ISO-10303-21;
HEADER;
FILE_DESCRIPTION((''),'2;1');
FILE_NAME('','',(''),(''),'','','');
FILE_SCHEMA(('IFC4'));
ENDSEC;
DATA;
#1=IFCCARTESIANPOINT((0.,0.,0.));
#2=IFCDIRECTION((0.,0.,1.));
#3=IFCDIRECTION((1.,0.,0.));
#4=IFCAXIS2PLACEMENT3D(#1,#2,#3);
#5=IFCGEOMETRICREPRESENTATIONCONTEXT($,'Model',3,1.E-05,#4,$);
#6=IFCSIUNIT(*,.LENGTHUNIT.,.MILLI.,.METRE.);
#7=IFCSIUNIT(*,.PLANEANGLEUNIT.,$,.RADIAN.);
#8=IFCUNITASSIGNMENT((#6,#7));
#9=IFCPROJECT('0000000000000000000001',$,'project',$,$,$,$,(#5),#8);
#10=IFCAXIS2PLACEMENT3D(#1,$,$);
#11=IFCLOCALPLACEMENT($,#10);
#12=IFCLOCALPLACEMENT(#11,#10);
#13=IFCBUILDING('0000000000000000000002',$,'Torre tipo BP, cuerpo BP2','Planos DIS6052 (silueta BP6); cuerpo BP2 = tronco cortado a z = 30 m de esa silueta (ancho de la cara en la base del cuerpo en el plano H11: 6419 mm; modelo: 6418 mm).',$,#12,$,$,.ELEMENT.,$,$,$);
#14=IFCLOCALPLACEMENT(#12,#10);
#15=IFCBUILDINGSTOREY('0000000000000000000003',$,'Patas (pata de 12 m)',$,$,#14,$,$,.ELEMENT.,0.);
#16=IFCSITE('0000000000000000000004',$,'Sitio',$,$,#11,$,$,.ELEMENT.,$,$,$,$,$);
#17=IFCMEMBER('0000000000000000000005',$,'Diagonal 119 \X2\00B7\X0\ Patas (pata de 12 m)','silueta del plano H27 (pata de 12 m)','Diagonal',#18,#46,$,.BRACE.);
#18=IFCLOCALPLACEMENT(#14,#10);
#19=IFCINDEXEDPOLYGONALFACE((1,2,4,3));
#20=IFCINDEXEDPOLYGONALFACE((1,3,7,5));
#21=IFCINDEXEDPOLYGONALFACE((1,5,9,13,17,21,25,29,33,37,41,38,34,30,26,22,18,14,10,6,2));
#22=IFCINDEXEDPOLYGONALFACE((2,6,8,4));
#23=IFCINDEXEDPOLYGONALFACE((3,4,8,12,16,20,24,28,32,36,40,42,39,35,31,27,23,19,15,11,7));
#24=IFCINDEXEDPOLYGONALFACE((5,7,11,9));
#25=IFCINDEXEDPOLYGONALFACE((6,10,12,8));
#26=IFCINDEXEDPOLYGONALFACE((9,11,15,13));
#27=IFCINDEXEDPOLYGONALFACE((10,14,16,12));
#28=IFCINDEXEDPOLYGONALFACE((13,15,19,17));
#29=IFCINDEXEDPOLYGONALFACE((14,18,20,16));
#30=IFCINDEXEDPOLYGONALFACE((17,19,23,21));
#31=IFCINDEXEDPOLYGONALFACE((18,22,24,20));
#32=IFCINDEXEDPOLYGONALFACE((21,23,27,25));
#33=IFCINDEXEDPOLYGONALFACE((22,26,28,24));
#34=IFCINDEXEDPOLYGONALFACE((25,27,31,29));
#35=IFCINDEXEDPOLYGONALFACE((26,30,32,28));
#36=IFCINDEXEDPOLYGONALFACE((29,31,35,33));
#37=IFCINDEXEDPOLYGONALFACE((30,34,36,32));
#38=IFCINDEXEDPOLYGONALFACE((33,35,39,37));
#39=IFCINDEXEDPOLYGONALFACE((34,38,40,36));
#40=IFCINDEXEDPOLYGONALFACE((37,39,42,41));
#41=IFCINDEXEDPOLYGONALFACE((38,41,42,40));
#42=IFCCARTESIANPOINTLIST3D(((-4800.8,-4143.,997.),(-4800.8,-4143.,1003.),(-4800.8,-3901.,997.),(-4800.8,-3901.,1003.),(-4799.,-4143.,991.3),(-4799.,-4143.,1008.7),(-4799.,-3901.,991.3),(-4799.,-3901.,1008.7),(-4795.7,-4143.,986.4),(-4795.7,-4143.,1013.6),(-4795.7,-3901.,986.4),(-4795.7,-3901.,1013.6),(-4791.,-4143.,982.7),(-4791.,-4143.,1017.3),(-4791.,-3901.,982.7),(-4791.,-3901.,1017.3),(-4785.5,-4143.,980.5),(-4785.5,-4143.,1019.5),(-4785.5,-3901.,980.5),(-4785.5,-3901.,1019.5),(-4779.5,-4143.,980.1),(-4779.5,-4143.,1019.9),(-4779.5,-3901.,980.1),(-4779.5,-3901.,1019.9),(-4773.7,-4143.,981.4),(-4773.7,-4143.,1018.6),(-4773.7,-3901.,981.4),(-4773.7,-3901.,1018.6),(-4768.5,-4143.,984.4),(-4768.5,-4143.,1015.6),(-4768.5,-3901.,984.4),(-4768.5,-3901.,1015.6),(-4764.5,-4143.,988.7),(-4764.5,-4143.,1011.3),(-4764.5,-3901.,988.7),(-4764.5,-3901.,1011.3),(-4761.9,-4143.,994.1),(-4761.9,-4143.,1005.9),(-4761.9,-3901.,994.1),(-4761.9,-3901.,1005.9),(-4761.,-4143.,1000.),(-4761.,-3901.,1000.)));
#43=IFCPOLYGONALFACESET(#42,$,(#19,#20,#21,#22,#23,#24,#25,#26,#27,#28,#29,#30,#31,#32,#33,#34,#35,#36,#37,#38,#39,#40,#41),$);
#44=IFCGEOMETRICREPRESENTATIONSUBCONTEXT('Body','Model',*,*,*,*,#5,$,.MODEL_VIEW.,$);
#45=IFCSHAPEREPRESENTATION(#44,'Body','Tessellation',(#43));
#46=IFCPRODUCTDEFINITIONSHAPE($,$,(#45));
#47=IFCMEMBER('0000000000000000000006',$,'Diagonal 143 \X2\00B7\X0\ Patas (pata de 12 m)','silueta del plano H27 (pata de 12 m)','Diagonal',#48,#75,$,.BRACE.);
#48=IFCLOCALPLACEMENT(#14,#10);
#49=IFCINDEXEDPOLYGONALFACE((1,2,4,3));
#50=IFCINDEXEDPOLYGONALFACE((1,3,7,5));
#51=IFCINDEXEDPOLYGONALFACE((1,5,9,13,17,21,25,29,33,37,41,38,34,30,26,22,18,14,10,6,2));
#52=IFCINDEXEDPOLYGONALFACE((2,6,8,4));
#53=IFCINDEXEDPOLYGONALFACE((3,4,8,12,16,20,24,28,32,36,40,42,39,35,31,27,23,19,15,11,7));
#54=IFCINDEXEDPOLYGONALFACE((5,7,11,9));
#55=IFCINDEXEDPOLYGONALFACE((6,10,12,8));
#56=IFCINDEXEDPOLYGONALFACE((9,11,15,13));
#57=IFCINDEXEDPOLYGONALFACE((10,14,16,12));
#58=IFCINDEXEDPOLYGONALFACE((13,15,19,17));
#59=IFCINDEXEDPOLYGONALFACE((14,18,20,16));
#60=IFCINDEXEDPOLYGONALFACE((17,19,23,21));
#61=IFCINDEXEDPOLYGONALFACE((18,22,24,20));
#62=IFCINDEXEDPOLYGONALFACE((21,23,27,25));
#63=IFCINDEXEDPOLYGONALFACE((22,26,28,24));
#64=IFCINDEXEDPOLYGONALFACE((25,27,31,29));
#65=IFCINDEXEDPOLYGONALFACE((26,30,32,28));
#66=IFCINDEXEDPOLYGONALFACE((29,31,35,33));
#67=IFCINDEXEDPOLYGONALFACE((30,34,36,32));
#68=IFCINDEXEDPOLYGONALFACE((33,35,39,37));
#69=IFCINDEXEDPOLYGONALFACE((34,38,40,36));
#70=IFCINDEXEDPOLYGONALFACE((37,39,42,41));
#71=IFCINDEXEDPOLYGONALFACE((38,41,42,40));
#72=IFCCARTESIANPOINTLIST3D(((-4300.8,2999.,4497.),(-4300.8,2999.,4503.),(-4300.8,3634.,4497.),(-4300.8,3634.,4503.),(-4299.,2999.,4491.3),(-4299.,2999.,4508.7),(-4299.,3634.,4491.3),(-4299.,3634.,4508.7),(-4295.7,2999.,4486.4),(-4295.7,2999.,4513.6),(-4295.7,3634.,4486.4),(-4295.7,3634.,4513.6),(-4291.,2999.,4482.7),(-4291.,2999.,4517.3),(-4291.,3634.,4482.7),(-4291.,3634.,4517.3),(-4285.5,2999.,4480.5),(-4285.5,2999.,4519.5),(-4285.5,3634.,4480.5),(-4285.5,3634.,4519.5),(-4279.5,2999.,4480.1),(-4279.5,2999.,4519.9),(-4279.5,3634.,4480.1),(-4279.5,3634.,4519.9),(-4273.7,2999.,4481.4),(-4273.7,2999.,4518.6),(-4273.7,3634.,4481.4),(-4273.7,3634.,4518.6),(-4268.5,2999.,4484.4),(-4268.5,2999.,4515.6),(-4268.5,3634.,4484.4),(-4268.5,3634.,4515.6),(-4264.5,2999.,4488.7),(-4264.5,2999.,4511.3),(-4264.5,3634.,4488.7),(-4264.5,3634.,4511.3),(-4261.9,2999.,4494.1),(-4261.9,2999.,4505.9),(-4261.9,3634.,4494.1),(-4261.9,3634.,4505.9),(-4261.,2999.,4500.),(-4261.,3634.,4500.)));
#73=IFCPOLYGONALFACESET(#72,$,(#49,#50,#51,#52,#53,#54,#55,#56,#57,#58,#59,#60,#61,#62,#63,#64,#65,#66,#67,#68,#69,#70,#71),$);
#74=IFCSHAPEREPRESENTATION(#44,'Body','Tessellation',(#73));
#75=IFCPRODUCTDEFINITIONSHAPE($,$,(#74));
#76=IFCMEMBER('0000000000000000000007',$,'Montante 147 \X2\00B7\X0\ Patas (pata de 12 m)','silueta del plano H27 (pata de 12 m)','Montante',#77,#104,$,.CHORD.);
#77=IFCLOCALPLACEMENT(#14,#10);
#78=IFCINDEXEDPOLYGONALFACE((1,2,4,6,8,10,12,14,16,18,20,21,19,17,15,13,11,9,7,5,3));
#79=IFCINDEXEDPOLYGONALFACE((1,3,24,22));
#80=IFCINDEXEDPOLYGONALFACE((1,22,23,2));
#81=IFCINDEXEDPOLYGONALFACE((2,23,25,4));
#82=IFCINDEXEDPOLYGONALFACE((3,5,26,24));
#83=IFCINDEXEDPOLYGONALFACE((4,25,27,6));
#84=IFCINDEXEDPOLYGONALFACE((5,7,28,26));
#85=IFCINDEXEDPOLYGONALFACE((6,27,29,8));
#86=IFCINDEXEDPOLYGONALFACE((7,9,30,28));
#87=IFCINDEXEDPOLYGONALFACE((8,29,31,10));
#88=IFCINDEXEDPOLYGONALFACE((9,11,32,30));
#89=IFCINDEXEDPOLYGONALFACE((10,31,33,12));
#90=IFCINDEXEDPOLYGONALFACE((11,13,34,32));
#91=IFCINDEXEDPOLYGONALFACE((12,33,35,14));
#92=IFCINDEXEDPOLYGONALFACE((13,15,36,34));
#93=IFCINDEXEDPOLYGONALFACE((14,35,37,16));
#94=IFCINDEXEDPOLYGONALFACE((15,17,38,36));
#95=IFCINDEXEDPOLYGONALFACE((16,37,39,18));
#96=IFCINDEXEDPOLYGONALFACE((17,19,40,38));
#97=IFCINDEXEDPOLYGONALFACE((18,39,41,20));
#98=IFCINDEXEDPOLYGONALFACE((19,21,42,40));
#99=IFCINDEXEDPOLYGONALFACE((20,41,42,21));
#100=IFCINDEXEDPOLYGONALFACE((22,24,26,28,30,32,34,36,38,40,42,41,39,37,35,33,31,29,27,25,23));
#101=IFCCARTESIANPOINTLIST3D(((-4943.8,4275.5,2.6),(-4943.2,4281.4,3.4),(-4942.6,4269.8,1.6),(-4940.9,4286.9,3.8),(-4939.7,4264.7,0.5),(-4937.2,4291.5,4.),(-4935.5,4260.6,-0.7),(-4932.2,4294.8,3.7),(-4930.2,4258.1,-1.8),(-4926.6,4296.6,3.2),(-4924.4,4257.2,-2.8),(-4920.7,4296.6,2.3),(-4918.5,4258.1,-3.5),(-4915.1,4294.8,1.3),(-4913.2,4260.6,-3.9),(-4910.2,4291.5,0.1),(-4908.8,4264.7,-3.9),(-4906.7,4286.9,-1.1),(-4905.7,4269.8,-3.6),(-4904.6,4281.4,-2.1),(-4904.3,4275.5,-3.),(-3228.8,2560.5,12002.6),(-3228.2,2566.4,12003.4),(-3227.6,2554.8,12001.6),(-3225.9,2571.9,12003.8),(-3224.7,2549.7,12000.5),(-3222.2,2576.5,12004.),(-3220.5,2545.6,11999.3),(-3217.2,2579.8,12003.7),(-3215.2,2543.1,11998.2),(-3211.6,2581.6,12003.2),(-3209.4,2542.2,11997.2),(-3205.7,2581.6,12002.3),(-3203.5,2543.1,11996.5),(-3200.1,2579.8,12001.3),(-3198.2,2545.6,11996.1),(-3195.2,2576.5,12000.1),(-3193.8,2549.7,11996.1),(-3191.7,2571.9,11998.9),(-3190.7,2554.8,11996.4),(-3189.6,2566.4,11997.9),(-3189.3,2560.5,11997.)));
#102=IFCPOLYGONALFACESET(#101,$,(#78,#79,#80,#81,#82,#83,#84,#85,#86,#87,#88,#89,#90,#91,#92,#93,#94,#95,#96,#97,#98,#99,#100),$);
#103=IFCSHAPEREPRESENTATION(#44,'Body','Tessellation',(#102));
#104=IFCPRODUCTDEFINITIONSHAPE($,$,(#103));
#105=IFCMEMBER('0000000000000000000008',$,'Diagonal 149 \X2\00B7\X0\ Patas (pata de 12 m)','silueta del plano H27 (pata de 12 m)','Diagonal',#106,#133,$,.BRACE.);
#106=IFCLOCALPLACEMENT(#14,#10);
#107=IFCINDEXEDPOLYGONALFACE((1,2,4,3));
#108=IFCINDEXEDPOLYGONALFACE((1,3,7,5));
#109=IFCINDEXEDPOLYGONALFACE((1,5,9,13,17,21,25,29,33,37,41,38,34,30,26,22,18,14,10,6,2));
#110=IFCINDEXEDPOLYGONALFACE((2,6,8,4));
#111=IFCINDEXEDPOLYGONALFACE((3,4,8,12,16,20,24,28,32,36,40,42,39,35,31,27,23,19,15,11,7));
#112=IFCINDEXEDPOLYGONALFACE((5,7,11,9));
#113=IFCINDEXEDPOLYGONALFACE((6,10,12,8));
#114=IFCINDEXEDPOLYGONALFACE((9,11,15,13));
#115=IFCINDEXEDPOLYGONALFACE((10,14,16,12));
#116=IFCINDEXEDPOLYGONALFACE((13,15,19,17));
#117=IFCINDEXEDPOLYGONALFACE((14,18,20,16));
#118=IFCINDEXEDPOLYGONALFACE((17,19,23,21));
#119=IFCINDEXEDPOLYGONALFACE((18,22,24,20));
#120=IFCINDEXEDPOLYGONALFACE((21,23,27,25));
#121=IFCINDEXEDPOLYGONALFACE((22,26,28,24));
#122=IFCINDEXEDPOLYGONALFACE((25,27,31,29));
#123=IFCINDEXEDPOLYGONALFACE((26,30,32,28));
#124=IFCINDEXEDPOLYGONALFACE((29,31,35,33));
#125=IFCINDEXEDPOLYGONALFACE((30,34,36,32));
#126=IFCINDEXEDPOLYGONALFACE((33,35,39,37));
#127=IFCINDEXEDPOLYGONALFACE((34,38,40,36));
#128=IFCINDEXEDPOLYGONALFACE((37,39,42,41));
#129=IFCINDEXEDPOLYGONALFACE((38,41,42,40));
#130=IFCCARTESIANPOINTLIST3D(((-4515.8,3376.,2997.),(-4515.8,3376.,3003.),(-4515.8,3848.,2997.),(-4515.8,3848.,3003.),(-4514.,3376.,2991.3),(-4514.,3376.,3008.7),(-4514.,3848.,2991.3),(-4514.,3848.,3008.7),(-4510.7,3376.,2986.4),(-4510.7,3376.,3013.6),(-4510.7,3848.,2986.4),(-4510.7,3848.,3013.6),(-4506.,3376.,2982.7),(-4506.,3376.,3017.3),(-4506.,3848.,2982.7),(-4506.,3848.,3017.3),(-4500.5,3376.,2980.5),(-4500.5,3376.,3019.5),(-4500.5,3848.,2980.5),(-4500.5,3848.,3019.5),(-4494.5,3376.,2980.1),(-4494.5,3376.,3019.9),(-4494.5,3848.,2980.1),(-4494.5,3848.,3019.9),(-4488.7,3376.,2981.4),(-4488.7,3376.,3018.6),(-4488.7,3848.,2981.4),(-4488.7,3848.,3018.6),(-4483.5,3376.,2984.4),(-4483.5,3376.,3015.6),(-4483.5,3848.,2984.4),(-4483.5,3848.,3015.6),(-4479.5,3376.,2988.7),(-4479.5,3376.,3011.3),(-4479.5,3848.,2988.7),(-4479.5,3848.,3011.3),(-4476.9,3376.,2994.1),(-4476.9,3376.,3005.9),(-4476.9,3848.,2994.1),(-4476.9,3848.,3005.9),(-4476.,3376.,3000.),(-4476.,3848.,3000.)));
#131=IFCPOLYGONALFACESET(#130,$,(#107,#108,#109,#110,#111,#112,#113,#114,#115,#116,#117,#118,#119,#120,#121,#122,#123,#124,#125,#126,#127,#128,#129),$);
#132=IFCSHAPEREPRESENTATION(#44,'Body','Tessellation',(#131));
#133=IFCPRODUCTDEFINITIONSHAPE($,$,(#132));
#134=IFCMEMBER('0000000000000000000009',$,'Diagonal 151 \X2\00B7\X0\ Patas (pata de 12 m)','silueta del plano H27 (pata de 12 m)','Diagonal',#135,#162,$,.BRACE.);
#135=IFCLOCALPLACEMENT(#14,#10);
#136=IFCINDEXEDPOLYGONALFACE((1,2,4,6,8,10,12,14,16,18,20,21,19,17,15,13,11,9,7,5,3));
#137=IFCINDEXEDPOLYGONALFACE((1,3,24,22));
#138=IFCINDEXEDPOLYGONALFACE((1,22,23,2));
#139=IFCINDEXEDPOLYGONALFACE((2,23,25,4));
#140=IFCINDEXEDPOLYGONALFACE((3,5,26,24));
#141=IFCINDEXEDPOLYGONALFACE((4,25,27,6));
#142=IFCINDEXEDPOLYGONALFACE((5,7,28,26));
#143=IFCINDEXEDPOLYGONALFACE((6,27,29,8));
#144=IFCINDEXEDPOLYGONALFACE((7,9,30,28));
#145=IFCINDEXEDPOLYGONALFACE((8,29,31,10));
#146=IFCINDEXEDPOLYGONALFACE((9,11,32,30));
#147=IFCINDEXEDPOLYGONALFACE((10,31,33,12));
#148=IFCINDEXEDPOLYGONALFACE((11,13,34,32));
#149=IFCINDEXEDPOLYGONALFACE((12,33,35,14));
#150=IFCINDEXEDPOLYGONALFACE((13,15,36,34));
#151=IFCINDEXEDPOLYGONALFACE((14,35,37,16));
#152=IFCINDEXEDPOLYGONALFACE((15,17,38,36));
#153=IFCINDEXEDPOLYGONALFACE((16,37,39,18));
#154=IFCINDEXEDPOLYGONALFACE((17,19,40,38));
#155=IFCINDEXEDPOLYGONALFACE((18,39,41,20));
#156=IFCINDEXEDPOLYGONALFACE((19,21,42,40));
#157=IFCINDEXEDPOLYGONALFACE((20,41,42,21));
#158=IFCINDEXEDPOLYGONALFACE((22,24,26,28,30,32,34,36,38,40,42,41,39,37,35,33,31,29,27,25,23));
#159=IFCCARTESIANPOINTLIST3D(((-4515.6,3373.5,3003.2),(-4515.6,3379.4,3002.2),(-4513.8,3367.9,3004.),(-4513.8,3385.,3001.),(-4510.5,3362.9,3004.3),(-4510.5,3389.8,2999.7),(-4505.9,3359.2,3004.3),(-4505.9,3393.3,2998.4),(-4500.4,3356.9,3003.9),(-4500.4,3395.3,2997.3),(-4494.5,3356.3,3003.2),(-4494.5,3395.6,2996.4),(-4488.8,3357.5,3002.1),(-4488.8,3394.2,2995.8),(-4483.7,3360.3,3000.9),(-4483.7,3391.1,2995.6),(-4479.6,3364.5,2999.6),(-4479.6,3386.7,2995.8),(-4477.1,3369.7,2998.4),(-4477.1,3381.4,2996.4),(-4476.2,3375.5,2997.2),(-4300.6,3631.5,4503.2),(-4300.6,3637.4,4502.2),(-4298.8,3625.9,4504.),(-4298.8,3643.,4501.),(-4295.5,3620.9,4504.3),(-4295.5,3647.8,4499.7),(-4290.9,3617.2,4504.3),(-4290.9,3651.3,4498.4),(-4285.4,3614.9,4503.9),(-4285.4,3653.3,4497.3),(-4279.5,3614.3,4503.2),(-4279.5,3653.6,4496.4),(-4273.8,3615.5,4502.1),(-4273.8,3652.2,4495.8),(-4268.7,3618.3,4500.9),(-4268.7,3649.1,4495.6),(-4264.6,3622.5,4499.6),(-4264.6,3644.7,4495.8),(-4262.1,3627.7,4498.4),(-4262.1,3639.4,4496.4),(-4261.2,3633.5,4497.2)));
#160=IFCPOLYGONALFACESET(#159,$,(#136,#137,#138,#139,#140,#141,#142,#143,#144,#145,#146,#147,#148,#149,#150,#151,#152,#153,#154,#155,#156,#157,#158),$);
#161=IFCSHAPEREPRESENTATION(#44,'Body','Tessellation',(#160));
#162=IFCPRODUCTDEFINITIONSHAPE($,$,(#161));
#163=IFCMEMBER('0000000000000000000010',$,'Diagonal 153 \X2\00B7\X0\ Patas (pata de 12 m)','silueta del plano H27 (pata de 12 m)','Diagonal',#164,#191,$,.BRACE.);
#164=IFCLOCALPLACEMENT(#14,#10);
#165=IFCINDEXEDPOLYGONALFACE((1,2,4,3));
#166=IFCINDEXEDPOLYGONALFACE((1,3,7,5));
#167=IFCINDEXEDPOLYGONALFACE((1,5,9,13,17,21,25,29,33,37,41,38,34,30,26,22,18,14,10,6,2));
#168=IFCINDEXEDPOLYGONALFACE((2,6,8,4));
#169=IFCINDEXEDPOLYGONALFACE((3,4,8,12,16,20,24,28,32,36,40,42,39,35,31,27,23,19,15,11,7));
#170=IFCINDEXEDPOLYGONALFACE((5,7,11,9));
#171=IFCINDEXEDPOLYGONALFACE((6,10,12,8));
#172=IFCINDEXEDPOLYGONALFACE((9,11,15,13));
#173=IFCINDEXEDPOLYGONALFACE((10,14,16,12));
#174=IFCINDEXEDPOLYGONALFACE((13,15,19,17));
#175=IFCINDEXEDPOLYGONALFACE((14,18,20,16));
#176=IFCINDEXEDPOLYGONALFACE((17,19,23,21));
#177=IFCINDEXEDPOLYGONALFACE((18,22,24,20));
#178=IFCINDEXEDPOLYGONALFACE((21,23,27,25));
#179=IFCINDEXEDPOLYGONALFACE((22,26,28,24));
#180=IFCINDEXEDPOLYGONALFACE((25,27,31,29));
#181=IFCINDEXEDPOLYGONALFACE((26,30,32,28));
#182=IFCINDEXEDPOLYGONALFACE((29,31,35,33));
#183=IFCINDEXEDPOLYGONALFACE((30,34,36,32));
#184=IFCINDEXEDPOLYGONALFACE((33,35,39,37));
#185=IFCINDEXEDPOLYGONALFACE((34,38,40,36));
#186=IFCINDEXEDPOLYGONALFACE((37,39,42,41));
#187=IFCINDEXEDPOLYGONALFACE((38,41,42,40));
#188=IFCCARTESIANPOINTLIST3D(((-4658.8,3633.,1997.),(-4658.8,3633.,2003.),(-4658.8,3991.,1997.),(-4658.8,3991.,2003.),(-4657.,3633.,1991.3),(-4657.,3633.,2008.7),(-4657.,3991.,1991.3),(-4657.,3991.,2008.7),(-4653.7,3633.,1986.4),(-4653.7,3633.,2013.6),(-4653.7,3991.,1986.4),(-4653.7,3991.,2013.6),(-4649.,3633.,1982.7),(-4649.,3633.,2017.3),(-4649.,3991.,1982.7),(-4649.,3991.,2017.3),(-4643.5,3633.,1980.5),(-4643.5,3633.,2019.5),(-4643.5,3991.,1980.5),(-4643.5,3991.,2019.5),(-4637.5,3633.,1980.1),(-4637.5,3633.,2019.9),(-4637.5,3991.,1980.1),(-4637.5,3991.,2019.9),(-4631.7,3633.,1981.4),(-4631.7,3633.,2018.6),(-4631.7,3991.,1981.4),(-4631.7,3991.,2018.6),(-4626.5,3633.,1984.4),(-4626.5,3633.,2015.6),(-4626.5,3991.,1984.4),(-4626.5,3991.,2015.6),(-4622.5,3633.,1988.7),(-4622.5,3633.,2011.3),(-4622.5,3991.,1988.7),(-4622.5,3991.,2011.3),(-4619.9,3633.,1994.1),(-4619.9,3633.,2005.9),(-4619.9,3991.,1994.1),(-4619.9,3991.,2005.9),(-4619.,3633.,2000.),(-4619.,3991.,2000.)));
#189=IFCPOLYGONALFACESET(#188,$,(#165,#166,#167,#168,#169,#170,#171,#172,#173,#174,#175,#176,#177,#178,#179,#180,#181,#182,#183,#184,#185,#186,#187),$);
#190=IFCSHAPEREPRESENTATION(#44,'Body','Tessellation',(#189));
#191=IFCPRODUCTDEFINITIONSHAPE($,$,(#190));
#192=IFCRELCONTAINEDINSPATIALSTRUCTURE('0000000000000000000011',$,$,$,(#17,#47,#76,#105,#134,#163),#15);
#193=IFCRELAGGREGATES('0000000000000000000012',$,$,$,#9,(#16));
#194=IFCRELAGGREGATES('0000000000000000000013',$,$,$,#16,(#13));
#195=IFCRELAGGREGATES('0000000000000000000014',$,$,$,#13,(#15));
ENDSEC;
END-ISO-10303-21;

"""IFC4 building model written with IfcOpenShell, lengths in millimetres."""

from ifc_helpers import new_model, si_unit, frame, origin, origin_with_axes, place, context, subcontext, project, spatial, circle, extrude, element, save


model = new_model("IFC4")

# Units and contexts
model_context = context("Model", 3, precision=1e-05, world=origin_with_axes())
body_context = subcontext(model_context, "Body", "Model", "MODEL_VIEW")
ifc_project = project(units=[si_unit("LENGTHUNIT", "METRE", prefix="MILLI"), si_unit("PLANEANGLEUNIT", "RADIAN")], contexts=[model_context])

# Site, building, storey
site_placement = place(None, origin())
site = spatial("IfcSite", under=ifc_project, at=site_placement, Name="Sitio", CompositionType="ELEMENT")
building_placement = place(site_placement, origin())
building = spatial("IfcBuilding", under=site, at=building_placement, Name="Torre tipo BP, cuerpo BP2", Description="Planos DIS6052 (silueta BP6); cuerpo BP2 = tronco cortado a z = 30 m de esa silueta (ancho de la cara en la base del cuerpo en el plano H11: 6419 mm; modelo: 6418 mm).", CompositionType="ELEMENT")
storey_placement = place(building_placement, origin())
storey = spatial("IfcBuildingStorey", under=building, at=storey_placement, Name="Patas (pata de 12 m)", CompositionType="ELEMENT", Elevation=0.0)

# Members
member_1_placement = place(storey_placement, frame((-4781.0, -4143.0, 1000.0), z_axis=(0.0, 1.0, 0.0), x_axis=(1.0, 0.0, 0.0)))
element("IfcMember", 1, at=member_1_placement, inside=storey, Name="Diagonal 119 · Patas (pata de 12 m)", Description="silueta del plano H27 (pata de 12 m)", ObjectType="Diagonal", PredefinedType="BRACE", context=body_context, shape_type="SweptSolid", body=[
    extrude(circle(Radius=20.0), None, (0.0, 0.0, 1.0), 242.0),
])
member_2_placement = place(storey_placement, frame((-4281.0, 3634.0, 4500.0), z_axis=(0.0, -1.0, 0.0), x_axis=(1.0, 0.0, 0.0)))
element("IfcMember", 2, at=member_2_placement, inside=storey, Name="Diagonal 143 · Patas (pata de 12 m)", Description="silueta del plano H27 (pata de 12 m)", ObjectType="Diagonal", PredefinedType="BRACE", context=body_context, shape_type="SweptSolid", body=[
    extrude(circle(Radius=20.0), None, (0.0, 0.0, 1.0), 635.0),
])
member_3_placement = place(storey_placement, frame((-4924.0, 4277.0, 0.0), z_axis=(0.140084, -0.140084, 0.98018), x_axis=(-0.019819, -0.99014, -0.138675)))
element("IfcMember", 3, at=member_3_placement, inside=storey, Name="Montante 147 · Patas (pata de 12 m)", Description="silueta del plano H27 (pata de 12 m)", ObjectType="Montante", PredefinedType="CHORD", context=body_context, shape_type="SweptSolid", body=[
    extrude(circle(Radius=20.0), None, (0.0, 0.0, 1.0), 12242.6),
])
member_4_placement = place(storey_placement, frame((-4496.0, 3848.0, 3000.0), z_axis=(0.0, -1.0, 0.0), x_axis=(1.0, 0.0, 0.0)))
element("IfcMember", 4, at=member_4_placement, inside=storey, Name="Diagonal 149 · Patas (pata de 12 m)", Description="silueta del plano H27 (pata de 12 m)", ObjectType="Diagonal", PredefinedType="BRACE", context=body_context, shape_type="SweptSolid", body=[
    extrude(circle(Radius=20.0), None, (0.0, 0.0, 1.0), 472.0),
])
member_5_placement = place(storey_placement, frame((-4496.0, 3376.0, 3000.0), z_axis=(0.13987, 0.167845, 0.97584), x_axis=(0.99017, -0.02371, -0.137846)))
element("IfcMember", 5, at=member_5_placement, inside=storey, Name="Diagonal 151 · Patas (pata de 12 m)", Description="silueta del plano H27 (pata de 12 m)", ObjectType="Diagonal", PredefinedType="BRACE", context=body_context, shape_type="SweptSolid", body=[
    extrude(circle(Radius=20.0), None, (0.0, 0.0, 1.0), 1537.1),
])
member_6_placement = place(storey_placement, frame((-4639.0, 3991.0, 2000.0), z_axis=(0.0, -1.0, 0.0), x_axis=(1.0, 0.0, 0.0)))
element("IfcMember", 6, at=member_6_placement, inside=storey, Name="Diagonal 153 · Patas (pata de 12 m)", Description="silueta del plano H27 (pata de 12 m)", ObjectType="Diagonal", PredefinedType="BRACE", context=body_context, shape_type="SweptSolid", body=[
    extrude(circle(Radius=20.0), None, (0.0, 0.0, 1.0), 358.0),
])

save(model, "model.ifc")
